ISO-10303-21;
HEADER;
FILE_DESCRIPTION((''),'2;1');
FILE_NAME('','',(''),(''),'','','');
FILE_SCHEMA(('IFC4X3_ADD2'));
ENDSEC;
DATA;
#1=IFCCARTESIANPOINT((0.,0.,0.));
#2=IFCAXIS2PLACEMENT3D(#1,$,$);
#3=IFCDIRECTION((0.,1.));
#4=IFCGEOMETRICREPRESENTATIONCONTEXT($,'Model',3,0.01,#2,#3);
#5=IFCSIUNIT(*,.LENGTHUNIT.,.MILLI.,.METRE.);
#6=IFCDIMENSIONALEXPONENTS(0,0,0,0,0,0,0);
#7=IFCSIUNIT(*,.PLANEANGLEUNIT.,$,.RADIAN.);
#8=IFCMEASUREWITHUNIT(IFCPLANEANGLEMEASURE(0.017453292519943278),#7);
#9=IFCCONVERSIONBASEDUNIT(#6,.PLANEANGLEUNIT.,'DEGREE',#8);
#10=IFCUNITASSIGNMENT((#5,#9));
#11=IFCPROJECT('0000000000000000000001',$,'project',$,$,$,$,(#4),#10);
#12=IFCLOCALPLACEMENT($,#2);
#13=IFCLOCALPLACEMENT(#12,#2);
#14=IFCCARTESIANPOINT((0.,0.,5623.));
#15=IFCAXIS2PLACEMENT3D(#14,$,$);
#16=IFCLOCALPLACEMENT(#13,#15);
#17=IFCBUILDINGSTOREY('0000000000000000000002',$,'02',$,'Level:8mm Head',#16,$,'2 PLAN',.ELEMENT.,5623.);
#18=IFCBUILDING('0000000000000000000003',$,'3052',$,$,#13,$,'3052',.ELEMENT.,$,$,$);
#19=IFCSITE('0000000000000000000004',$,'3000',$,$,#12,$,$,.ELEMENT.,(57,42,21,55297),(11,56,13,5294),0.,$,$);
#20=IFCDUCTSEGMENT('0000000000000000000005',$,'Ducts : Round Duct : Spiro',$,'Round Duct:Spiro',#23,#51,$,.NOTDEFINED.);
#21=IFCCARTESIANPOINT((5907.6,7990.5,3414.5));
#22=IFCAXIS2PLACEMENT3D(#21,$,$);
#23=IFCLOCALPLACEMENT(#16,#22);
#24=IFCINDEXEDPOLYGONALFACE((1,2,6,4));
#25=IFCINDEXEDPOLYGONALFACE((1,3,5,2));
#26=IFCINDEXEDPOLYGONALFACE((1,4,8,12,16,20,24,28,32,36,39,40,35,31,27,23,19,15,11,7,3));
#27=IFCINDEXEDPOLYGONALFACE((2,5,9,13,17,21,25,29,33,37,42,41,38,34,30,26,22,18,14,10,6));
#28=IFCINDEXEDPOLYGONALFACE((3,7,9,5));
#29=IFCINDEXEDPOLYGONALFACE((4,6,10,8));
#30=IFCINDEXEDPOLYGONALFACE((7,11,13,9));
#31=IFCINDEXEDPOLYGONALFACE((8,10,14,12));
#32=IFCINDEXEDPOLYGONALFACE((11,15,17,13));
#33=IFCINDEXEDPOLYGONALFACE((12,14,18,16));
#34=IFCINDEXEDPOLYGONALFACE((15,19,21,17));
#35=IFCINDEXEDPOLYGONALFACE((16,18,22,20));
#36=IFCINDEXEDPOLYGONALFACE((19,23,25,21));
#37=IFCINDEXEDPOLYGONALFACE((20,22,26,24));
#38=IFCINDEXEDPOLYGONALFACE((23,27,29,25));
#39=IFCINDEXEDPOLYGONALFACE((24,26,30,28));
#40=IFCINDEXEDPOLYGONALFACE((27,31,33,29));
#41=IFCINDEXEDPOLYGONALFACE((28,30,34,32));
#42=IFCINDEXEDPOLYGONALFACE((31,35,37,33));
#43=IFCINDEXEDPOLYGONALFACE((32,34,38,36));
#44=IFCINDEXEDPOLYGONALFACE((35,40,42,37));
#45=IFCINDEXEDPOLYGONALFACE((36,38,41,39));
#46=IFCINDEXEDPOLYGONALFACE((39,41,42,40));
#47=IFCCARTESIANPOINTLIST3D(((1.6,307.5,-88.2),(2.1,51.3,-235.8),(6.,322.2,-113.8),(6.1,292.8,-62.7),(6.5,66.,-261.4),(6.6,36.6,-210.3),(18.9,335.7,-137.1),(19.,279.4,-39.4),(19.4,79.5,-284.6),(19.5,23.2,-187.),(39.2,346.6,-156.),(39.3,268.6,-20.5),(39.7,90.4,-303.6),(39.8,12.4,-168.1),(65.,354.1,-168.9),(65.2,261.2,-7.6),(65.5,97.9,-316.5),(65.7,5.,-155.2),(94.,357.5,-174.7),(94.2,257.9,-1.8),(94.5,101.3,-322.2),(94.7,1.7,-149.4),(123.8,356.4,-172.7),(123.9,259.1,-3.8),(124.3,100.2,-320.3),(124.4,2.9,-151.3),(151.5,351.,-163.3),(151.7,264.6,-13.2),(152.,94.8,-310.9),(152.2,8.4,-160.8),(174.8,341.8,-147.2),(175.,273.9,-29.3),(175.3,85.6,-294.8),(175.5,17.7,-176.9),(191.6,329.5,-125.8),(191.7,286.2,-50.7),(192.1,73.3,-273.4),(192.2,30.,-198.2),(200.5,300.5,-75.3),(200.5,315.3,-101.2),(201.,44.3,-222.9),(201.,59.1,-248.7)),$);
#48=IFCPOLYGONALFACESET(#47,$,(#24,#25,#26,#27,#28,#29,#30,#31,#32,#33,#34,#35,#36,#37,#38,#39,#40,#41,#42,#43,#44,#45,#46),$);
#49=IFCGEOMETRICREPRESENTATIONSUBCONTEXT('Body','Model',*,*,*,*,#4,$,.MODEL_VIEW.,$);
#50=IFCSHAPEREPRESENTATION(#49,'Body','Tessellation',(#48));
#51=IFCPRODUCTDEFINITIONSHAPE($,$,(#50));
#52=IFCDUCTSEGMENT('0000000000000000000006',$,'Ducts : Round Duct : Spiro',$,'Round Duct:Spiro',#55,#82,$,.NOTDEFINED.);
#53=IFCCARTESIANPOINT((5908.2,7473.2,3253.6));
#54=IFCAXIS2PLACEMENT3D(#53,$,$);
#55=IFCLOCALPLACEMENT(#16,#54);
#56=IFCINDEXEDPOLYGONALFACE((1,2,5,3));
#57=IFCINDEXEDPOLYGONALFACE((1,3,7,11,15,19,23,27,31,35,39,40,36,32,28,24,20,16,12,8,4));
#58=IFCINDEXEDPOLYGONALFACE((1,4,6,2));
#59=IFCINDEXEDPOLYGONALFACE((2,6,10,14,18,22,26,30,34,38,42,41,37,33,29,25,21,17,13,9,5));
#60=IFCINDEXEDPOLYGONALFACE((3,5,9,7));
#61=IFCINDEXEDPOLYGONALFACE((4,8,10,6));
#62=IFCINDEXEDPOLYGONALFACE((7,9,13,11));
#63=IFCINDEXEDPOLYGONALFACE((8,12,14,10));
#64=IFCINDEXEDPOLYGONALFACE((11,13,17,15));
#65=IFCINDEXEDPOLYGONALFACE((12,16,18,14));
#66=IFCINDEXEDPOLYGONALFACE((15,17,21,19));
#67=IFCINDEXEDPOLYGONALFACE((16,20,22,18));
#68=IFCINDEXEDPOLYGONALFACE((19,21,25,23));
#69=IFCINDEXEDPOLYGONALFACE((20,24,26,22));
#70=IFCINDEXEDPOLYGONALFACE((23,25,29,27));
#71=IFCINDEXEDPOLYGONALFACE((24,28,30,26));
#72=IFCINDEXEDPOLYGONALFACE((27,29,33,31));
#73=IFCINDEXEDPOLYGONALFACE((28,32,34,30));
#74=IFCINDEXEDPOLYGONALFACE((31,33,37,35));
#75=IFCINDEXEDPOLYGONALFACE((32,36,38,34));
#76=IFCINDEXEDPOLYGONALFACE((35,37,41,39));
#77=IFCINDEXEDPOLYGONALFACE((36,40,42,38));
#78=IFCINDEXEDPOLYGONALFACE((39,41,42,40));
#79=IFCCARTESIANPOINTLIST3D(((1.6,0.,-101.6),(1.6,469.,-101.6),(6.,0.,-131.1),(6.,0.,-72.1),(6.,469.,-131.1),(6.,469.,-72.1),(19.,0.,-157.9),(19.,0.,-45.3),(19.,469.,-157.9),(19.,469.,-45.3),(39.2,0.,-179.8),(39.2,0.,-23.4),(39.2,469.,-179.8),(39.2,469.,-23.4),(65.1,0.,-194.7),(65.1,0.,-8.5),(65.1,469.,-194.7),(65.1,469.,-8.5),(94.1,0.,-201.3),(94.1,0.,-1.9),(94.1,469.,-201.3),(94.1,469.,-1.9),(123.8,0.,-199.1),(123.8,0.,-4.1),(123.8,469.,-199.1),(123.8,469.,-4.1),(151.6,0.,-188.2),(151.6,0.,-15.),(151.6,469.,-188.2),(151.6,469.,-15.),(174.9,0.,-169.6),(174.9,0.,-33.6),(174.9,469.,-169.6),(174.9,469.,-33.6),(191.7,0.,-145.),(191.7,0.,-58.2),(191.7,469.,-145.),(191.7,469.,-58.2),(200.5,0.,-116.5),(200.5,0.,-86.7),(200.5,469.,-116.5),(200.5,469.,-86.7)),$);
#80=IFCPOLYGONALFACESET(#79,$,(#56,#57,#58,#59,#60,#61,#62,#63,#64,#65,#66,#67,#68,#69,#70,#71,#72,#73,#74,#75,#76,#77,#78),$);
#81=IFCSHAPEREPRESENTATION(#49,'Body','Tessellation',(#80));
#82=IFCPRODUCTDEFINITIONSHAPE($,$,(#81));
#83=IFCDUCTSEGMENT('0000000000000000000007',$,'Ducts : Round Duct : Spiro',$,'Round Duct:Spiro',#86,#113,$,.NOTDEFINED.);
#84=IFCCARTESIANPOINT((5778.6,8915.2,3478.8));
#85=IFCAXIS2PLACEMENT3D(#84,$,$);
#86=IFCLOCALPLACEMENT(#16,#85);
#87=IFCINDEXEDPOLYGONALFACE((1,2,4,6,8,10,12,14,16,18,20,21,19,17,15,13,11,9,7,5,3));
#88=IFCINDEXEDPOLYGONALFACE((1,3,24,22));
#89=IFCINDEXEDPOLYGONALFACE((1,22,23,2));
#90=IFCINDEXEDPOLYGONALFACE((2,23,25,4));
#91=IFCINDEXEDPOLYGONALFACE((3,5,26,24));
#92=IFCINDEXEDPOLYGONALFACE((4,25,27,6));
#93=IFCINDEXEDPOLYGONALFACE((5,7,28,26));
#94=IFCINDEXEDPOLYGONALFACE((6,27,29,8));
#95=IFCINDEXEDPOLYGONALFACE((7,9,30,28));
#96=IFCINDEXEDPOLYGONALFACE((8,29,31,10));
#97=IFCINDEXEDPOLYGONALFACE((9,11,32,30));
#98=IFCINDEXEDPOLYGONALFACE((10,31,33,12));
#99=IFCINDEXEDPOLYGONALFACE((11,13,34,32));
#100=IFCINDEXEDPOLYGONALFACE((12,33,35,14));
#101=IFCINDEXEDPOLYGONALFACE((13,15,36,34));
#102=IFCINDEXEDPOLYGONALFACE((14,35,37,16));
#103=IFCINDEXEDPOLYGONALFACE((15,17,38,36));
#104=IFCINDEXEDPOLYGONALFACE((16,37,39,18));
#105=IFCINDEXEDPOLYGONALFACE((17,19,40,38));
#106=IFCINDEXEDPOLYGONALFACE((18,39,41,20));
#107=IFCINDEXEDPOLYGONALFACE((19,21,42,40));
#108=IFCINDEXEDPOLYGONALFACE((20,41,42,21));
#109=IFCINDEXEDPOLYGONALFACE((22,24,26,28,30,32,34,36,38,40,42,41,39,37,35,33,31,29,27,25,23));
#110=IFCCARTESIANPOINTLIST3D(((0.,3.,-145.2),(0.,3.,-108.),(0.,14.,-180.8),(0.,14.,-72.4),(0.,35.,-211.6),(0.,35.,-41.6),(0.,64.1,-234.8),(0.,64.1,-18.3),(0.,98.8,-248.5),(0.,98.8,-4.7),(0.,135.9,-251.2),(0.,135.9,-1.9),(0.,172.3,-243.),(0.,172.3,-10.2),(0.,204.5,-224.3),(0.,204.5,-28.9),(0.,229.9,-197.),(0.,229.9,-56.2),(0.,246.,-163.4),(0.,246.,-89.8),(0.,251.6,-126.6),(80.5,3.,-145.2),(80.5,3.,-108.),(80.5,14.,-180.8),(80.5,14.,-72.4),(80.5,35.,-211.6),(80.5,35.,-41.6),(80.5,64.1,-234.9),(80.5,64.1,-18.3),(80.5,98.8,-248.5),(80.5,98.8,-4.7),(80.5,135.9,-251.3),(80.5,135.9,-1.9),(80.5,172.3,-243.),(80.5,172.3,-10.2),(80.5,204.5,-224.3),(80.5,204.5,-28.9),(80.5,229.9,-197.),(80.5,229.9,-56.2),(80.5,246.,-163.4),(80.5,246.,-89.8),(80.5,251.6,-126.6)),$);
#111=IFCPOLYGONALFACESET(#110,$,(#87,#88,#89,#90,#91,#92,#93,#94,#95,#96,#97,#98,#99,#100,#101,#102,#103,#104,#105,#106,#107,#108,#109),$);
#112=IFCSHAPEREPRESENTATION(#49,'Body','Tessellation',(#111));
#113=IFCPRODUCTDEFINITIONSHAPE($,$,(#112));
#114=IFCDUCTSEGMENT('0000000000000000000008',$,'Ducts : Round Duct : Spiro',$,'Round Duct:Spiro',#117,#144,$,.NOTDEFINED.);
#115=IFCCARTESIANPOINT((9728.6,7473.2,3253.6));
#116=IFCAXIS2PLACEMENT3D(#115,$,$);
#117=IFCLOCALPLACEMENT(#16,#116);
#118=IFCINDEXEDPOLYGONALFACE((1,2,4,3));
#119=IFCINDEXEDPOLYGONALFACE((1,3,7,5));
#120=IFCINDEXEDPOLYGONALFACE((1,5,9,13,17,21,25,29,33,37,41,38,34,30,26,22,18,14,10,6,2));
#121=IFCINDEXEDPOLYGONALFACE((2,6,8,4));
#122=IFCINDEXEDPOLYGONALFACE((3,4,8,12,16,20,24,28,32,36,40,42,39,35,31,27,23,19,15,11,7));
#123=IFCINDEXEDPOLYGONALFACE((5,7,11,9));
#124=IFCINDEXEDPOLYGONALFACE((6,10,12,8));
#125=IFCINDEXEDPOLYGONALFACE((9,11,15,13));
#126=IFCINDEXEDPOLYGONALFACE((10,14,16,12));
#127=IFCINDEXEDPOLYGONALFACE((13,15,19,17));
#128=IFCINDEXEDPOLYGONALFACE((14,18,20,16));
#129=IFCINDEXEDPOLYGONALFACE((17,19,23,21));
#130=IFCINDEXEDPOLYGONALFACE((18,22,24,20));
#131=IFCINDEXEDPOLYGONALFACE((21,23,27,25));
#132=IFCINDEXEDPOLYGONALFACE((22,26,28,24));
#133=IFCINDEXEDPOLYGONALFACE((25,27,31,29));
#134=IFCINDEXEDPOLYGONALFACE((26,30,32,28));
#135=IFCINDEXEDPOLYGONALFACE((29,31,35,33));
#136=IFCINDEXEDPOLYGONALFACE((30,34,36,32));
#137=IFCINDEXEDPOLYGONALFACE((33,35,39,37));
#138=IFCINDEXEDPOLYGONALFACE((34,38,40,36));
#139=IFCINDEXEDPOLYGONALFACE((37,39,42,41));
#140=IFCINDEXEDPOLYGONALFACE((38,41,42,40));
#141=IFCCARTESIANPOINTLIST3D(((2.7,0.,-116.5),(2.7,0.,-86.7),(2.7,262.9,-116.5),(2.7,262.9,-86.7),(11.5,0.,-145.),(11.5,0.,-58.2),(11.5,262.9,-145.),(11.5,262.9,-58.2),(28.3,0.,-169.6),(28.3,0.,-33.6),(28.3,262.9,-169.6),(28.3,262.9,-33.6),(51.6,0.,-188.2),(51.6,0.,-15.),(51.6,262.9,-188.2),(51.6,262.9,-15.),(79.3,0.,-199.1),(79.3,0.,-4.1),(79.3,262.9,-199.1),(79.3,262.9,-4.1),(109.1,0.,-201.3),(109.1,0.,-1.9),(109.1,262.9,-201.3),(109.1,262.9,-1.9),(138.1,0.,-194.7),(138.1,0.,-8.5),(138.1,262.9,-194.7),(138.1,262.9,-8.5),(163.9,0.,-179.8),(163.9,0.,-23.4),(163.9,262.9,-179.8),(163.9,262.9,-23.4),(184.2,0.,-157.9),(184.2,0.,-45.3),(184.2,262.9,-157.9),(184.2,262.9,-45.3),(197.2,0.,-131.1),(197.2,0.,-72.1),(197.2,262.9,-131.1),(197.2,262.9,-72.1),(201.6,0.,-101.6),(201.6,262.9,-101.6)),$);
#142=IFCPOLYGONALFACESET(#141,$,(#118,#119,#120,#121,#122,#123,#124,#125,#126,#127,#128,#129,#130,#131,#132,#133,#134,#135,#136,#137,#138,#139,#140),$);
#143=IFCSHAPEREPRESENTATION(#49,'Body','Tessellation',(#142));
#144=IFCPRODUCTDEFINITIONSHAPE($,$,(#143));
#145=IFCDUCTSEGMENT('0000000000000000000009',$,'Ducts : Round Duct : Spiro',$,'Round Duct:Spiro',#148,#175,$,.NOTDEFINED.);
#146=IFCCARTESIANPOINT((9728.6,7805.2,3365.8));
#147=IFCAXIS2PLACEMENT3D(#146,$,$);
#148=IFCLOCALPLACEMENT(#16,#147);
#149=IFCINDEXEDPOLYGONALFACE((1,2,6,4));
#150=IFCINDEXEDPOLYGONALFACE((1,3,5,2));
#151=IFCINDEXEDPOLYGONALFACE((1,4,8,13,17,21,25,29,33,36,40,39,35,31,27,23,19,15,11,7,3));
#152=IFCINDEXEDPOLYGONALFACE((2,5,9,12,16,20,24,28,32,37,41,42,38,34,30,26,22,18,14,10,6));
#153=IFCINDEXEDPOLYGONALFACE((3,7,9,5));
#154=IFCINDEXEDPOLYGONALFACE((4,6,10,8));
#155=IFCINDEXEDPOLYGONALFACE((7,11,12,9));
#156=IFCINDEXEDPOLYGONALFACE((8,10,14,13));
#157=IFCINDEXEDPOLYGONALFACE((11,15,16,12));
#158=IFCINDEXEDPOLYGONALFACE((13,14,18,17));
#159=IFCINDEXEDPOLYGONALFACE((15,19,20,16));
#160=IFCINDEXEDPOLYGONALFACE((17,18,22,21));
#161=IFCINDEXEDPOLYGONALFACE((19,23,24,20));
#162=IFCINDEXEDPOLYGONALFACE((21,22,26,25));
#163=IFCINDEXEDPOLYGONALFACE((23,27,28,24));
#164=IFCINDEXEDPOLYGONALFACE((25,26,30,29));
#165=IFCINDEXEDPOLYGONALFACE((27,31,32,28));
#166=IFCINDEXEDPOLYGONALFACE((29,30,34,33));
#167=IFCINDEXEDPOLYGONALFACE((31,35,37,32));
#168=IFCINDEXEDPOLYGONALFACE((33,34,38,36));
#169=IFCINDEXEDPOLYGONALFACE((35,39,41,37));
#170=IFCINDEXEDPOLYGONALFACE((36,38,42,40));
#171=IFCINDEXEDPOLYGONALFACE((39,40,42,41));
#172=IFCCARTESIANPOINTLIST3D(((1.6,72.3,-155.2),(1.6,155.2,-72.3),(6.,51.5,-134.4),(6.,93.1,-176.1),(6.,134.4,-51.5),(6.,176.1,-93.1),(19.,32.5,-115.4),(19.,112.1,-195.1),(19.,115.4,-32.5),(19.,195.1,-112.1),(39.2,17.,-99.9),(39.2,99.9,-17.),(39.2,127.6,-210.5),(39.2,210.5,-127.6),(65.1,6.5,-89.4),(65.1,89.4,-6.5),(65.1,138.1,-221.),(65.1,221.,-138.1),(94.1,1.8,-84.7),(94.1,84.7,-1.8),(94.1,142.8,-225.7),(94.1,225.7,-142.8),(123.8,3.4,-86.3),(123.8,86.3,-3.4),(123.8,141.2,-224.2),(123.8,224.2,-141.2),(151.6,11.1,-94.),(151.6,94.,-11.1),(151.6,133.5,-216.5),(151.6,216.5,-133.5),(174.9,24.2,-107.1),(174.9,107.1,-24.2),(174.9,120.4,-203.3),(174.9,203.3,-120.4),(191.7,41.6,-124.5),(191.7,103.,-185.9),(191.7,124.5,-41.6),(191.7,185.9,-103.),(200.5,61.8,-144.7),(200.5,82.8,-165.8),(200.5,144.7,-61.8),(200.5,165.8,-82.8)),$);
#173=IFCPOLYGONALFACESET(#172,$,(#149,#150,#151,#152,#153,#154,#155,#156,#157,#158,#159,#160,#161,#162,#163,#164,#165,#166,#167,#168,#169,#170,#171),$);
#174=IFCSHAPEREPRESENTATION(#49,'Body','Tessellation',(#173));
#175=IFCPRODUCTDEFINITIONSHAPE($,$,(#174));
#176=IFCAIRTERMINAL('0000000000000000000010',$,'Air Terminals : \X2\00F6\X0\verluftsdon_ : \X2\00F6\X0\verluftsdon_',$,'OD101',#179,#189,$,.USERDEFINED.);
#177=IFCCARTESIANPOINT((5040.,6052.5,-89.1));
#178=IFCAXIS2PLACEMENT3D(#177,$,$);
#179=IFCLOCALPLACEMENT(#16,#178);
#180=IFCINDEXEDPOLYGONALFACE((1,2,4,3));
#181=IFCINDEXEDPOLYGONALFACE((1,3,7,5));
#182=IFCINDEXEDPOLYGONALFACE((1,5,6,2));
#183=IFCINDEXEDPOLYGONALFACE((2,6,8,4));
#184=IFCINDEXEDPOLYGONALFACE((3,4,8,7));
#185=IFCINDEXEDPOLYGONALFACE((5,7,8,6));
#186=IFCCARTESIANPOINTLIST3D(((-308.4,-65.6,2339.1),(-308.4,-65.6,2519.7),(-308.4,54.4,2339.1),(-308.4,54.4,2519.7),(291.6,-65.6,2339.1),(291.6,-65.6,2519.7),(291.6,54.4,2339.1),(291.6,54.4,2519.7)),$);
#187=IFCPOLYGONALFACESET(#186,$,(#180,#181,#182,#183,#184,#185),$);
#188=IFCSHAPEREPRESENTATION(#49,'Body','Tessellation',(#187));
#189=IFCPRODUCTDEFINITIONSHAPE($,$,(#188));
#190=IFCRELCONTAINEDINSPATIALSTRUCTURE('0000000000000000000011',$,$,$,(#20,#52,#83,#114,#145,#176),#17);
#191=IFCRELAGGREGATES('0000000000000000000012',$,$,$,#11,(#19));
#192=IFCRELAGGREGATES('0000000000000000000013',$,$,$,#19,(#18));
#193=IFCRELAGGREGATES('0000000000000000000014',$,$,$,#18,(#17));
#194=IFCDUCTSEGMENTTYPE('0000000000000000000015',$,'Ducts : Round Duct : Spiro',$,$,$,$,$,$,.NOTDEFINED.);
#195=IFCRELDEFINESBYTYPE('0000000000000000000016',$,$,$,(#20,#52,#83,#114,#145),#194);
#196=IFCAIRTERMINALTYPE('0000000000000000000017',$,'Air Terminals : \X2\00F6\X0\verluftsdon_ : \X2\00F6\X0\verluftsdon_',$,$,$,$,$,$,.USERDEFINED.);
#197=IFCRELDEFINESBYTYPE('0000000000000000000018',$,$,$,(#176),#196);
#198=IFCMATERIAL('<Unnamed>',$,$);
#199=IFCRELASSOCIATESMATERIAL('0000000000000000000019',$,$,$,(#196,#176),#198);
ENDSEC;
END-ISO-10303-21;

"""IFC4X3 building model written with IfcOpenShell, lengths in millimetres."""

from ifc_helpers import new_model, entity, si_unit, converted_unit, direction, frame, frame_2d, origin, origin_2d_with_axis, place, context, subcontext, project, spatial, rectangle, circle, extrude, source, transform, mapped, material, type_object, type_shapes, element, save


model = new_model("IFC4X3")

# Units and contexts
model_context = context("Model", 3, precision=0.01, world=origin(), true_north=direction((0.0, 1.0)))
body_context = subcontext(model_context, "Body", "Model", "MODEL_VIEW")
ifc_project = project(units=[si_unit("LENGTHUNIT", "METRE", prefix="MILLI"), converted_unit("PLANEANGLEUNIT", "DEGREE", entity("IfcPlaneAngleMeasure", 0.017453292519943278), si_unit("PLANEANGLEUNIT", "RADIAN"), dimensions=[0, 0, 0, 0, 0, 0, 0])], contexts=[model_context])

# Site, building, storey
site_placement = place(None, origin())
site = spatial("IfcSite", under=ifc_project, at=site_placement, Name="3000", CompositionType="ELEMENT", RefLatitude=(57, 42, 21, 55297), RefLongitude=(11, 56, 13, 5294), RefElevation=0.0)
building_placement = place(site_placement, origin())
building = spatial("IfcBuilding", under=site, at=building_placement, Name="3052", LongName="3052", CompositionType="ELEMENT")
storey_placement = place(building_placement, frame((0.0, 0.0, 5623.0)))
storey = spatial("IfcBuildingStorey", under=building, at=storey_placement, Name="02", ObjectType="Level:8mm Head", LongName="2 PLAN", CompositionType="ELEMENT", Elevation=5623.0)

# Duct segments
duct_segment_type = type_object("IfcDuctSegmentType", Name="Ducts : Round Duct : Spiro", PredefinedType="NOTDEFINED")
duct_segment_1_placement = place(storey_placement, frame((5907.6, 7990.5, 3414.5)))
element("IfcDuctSegment", 1, at=duct_segment_1_placement, inside=storey, type_object=duct_segment_type, Name="Ducts : Round Duct : Spiro", ObjectType="Round Duct:Spiro", PredefinedType="NOTDEFINED", context=body_context, shape_type="SweptSolid", body=[
    extrude(circle(Radius=100.0, at=origin_2d_with_axis()), frame((101.6, 307.7, -88.2), z_axis=(0.001692, -0.86651, -0.499156), x_axis=(-0.999998, -0.001954, 0.000002)), (0.0, 0.0, 1.0), 295.7),
])
duct_segment_2_placement = place(storey_placement, frame((5908.2, 7473.2, 3253.6)))
element("IfcDuctSegment", 2, at=duct_segment_2_placement, inside=storey, type_object=duct_segment_type, Name="Ducts : Round Duct : Spiro", ObjectType="Round Duct:Spiro", PredefinedType="NOTDEFINED", context=body_context, shape_type="SweptSolid", body=[
    extrude(circle(Radius=100.0, at=frame_2d((0.0, 0.0), x_axis=(1.0, 0.0))), frame((101.6, 0.0, -101.6), z_axis=(0.0, 1.0, 0.0), x_axis=(-1.0, 0.0, 0.0)), (0.0, 0.0, 1.0), 469.0),
])
duct_segment_3_placement = place(storey_placement, frame((5778.6, 8915.2, 3478.8)))
element("IfcDuctSegment", 3, at=duct_segment_3_placement, inside=storey, type_object=duct_segment_type, Name="Ducts : Round Duct : Spiro", ObjectType="Round Duct:Spiro", PredefinedType="NOTDEFINED", context=body_context, shape_type="SweptSolid", body=[
    extrude(circle(Radius=125.0, at=frame_2d((0.0, 0.0), x_axis=(1.0, 0.0))), frame((80.5, 126.6, -126.6), z_axis=(-1.0, 0.0, 0.000055), x_axis=(0.0, 1.0, 0.0)), (0.0, 0.0, 1.0), 80.5),
])
duct_segment_4_placement = place(storey_placement, frame((9728.6, 7473.2, 3253.6)))
element("IfcDuctSegment", 4, at=duct_segment_4_placement, inside=storey, type_object=duct_segment_type, Name="Ducts : Round Duct : Spiro", ObjectType="Round Duct:Spiro", PredefinedType="NOTDEFINED", context=body_context, shape_type="SweptSolid", body=[
    extrude(circle(Radius=100.0, at=frame_2d((0.0, 0.0), x_axis=(1.0, 0.0))), frame((101.6, 0.0, -101.6), z_axis=(0.0, 1.0, 0.0), x_axis=(1.0, 0.0, 0.0)), (0.0, 0.0, 1.0), 262.9),
])
duct_segment_5_placement = place(storey_placement, frame((9728.6, 7805.2, 3365.8)))
element("IfcDuctSegment", 5, at=duct_segment_5_placement, inside=storey, type_object=duct_segment_type, Name="Ducts : Round Duct : Spiro", ObjectType="Round Duct:Spiro", PredefinedType="NOTDEFINED", context=body_context, shape_type="SweptSolid", body=[
    extrude(circle(Radius=100.0, at=origin_2d_with_axis()), frame((101.6, 72.3, -155.2), z_axis=(0.0, 0.707107, 0.707107), x_axis=(-1.0, 0.0, 0.0)), (0.0, 0.0, 1.0), 117.3),
])

# Air terminal
ifc_material_1 = material(Name="<Unnamed>")
air_terminal_type_1 = type_object("IfcAirTerminalType", Name="Air Terminals : överluftsdon_ : överluftsdon_", PredefinedType="USERDEFINED", material=ifc_material_1)
shared_shape_1 = source(origin(), body_context, "Body", "SweptSolid", [
    extrude(rectangle(XDim=120.0, YDim=600.0, at=origin_2d_with_axis()), frame((-8.4, -5.6, 2339.1), z_axis=(0.0, 0.0, 1.0), x_axis=(0.0, 1.0, 0.0)), (0.0, 0.0, 1.0), 180.7),
])
type_shapes(air_terminal_type_1, [shared_shape_1])
air_terminal_1_placement = place(storey_placement, frame((5040.0, 6052.5, -89.1)))
element("IfcAirTerminal", 6, at=air_terminal_1_placement, inside=storey, type_object=air_terminal_type_1, material=ifc_material_1, Name="Air Terminals : överluftsdon_ : överluftsdon_", ObjectType="OD101", PredefinedType="USERDEFINED", context=body_context, shape_type="MappedRepresentation", body=[
    mapped(shared_shape_1, transform((0.0, 0.0, 0.0), scale=1.0)),
])

save(model, "model.ifc")
